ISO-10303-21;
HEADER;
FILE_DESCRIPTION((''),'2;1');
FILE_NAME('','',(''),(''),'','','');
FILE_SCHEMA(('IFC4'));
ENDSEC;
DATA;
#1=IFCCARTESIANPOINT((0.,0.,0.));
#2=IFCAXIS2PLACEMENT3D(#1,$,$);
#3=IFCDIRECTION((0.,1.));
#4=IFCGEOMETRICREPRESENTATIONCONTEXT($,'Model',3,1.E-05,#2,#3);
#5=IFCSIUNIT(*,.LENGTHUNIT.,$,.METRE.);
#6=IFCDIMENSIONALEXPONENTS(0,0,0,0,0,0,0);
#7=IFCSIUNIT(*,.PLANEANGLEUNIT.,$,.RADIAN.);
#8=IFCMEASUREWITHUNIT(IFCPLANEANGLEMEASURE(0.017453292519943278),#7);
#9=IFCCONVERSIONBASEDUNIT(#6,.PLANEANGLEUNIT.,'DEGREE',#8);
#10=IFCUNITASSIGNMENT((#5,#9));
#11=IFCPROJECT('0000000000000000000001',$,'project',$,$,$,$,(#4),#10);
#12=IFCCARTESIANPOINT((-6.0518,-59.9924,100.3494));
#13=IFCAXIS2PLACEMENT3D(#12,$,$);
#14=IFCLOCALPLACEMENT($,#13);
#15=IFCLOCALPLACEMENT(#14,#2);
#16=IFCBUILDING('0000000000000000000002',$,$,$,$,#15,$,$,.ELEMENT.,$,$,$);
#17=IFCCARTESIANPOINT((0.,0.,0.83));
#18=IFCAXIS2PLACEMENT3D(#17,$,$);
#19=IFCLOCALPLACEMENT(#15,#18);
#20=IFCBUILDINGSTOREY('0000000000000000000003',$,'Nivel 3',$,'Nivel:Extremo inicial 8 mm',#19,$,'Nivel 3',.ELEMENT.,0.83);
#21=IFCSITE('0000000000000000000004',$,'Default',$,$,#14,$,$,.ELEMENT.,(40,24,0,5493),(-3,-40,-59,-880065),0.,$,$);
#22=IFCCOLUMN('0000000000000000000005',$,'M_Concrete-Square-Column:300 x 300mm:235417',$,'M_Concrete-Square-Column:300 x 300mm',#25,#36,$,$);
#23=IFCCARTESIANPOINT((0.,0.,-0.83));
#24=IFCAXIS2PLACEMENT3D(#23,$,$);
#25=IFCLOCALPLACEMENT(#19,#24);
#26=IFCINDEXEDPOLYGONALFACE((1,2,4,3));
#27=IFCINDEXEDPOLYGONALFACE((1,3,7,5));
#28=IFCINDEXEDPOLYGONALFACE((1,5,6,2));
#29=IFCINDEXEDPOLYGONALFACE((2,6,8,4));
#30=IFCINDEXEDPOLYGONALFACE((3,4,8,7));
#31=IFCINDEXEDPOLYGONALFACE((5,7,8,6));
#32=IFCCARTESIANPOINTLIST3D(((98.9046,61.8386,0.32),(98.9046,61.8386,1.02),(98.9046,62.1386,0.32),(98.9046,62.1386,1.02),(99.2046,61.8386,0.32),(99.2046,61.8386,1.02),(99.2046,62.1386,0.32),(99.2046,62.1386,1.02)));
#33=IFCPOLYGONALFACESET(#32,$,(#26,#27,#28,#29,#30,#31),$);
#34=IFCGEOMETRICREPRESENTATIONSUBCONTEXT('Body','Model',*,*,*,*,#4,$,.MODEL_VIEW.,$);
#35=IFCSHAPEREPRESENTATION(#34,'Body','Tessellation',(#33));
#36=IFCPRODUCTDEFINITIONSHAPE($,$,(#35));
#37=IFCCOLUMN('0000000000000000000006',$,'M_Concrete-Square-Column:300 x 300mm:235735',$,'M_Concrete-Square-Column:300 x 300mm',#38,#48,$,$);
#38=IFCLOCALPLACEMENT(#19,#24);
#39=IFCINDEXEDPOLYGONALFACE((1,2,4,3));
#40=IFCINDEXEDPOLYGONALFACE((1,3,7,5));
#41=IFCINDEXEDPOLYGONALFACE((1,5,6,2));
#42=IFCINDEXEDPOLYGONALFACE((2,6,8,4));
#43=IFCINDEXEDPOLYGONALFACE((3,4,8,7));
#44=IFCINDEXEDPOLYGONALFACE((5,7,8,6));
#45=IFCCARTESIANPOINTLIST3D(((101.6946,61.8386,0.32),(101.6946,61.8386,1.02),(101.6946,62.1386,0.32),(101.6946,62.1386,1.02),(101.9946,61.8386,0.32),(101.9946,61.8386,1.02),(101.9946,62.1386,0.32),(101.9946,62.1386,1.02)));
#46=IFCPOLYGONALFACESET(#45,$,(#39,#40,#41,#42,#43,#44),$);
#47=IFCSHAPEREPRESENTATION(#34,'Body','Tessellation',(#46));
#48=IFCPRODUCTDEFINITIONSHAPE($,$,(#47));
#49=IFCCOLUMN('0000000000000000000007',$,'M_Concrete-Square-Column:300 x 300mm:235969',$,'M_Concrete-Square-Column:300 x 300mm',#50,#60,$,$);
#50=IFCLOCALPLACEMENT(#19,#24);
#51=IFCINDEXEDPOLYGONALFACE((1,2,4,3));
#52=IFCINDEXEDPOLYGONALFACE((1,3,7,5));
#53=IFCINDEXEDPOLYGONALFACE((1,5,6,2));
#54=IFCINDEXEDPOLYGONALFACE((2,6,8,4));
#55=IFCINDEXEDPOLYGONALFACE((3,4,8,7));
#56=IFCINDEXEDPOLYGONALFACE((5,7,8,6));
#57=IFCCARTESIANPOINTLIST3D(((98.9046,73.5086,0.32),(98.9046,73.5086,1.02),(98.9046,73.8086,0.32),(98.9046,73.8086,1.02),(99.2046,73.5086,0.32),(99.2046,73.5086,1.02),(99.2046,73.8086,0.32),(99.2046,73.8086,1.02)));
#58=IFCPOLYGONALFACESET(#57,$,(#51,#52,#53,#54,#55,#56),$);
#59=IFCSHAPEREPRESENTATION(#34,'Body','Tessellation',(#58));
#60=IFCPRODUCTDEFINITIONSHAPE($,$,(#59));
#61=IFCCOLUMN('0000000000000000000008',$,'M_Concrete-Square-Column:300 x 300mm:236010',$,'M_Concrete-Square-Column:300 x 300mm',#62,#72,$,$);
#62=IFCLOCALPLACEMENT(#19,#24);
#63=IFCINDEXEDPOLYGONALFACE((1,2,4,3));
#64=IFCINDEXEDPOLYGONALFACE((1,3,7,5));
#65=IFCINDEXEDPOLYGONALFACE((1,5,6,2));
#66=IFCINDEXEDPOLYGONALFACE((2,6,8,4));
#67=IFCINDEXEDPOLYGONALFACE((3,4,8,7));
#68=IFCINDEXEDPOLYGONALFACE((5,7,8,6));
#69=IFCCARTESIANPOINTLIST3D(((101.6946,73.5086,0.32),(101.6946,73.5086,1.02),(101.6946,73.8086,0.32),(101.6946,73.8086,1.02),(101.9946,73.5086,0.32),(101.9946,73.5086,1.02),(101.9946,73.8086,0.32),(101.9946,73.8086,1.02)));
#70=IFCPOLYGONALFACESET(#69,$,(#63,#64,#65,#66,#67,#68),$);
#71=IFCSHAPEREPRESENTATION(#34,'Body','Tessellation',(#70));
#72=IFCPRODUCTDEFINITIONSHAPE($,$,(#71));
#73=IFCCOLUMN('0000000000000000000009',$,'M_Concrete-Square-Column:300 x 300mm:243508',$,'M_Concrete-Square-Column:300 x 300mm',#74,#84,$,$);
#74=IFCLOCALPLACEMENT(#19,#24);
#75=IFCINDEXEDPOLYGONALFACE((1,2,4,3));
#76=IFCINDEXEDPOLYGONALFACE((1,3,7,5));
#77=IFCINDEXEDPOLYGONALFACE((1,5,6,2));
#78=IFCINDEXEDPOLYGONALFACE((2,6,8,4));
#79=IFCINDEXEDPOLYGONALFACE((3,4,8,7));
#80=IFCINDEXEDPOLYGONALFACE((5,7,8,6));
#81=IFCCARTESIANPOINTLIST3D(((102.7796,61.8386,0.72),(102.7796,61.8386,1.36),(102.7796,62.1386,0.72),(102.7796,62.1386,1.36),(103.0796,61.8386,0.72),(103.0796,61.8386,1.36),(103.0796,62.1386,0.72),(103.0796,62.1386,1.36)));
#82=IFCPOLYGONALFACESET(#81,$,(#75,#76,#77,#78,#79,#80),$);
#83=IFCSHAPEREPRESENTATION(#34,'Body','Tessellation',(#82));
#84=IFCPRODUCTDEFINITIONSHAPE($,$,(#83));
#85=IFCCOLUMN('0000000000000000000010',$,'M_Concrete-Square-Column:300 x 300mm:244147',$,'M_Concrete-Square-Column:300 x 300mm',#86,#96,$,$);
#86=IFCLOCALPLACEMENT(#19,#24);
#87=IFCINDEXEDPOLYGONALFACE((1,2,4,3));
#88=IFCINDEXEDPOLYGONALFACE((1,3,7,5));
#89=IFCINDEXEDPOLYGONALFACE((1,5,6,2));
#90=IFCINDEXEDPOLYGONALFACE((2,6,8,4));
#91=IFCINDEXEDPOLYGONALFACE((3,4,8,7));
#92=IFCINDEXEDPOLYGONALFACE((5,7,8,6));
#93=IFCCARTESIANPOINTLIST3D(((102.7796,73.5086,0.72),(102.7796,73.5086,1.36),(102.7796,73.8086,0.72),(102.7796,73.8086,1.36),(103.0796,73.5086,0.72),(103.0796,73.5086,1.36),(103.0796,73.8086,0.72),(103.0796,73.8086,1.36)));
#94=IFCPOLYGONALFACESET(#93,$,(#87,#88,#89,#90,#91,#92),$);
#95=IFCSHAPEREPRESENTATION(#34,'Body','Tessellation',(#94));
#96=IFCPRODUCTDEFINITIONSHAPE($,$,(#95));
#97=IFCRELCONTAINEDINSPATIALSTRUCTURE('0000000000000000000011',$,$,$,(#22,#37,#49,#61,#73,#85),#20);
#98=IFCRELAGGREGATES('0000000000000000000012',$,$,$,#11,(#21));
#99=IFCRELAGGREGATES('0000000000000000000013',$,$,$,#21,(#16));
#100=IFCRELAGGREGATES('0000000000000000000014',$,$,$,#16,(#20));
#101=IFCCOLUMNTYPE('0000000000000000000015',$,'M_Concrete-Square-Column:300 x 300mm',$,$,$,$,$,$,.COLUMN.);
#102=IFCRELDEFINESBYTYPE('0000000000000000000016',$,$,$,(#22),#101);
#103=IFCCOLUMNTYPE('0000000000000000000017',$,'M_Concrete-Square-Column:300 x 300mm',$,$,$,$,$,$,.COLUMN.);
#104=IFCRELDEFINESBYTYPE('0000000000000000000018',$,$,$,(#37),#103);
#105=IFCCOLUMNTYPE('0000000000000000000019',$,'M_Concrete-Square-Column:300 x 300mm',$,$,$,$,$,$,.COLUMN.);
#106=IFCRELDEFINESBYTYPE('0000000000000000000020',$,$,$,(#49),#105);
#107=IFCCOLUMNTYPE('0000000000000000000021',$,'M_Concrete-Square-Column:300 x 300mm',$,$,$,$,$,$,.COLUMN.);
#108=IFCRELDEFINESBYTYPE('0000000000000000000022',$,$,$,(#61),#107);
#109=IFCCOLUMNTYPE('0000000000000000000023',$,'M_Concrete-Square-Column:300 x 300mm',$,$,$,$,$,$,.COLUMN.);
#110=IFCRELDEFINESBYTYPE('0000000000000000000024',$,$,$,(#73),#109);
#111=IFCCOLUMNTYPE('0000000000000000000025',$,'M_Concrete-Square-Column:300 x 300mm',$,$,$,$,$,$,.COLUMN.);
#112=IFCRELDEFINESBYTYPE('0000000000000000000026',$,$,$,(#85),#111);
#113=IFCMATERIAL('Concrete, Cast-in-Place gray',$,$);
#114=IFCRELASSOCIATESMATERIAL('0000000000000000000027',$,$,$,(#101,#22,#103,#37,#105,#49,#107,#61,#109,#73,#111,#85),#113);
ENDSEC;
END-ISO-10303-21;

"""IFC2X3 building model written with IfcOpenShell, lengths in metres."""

from ifc_helpers import new_model, entity, si_unit, converted_unit, direction, frame, origin, origin_2d_with_axis, place, context, subcontext, project, spatial, rectangle, extrude, source, transform, mapped, material, type_object, type_shapes, element, save


model = new_model("IFC2X3")

# Units and contexts
model_context = context("Model", 3, precision=1e-05, world=origin(), true_north=direction((0.0, 1.0)))
body_context = subcontext(model_context, "Body", "Model", "MODEL_VIEW")
ifc_project = project(units=[si_unit("LENGTHUNIT", "METRE"), converted_unit("PLANEANGLEUNIT", "DEGREE", entity("IfcPlaneAngleMeasure", 0.017453292519943278), si_unit("PLANEANGLEUNIT", "RADIAN"), dimensions=[0, 0, 0, 0, 0, 0, 0])], contexts=[model_context])

# Site, building, storey
site_placement = place(None, frame((-6.0518, -59.9924, 100.3494)))
site = spatial("IfcSite", under=ifc_project, at=site_placement, Name="Default", CompositionType="ELEMENT", RefLatitude=(40, 24, 0, 5493), RefLongitude=(-3, -40, -59, -880065), RefElevation=0.0)
building_placement = place(site_placement, origin())
building = spatial("IfcBuilding", under=site, at=building_placement, CompositionType="ELEMENT")
storey_placement = place(building_placement, frame((0.0, 0.0, 0.83)))
storey = spatial("IfcBuildingStorey", under=building, at=storey_placement, Name="Nivel 3", ObjectType="Nivel:Extremo inicial 8 mm", LongName="Nivel 3", CompositionType="ELEMENT", Elevation=0.83)

# Columns
ifc_material_1 = material(Name="Concrete, Cast-in-Place gray")
column_type_1 = type_object("IfcColumnType", Name="M_Concrete-Square-Column:300 x 300mm", PredefinedType="COLUMN", material=ifc_material_1)
shared_shape_1 = source(origin(), body_context, "Body", "SweptSolid", [
    extrude(rectangle(XDim=0.3, YDim=0.3, at=origin_2d_with_axis()), frame((99.0546, 61.9886, 0.32), z_axis=(0.0, 0.0, 1.0), x_axis=(-1.0, 0.0, 0.0)), (0.0, 0.0, 1.0), 0.7),
])
type_shapes(column_type_1, [shared_shape_1])
column_1_placement = place(storey_placement, frame((0.0, 0.0, -0.83)))
element("IfcColumn", 1, at=column_1_placement, inside=storey, type_object=column_type_1, material=ifc_material_1, Name="M_Concrete-Square-Column:300 x 300mm:235417", ObjectType="M_Concrete-Square-Column:300 x 300mm", context=body_context, shape_type="MappedRepresentation", body=[
    mapped(shared_shape_1, transform((0.0, 0.0, 0.0), scale=1.0)),
])
column_type_2 = type_object("IfcColumnType", Name="M_Concrete-Square-Column:300 x 300mm", PredefinedType="COLUMN", material=ifc_material_1)
shared_shape_2 = source(origin(), body_context, "Body", "SweptSolid", [
    extrude(rectangle(XDim=0.3, YDim=0.3, at=origin_2d_with_axis()), frame((101.8446, 61.9886, 0.32), z_axis=(0.0, 0.0, 1.0), x_axis=(-1.0, 0.0, 0.0)), (0.0, 0.0, 1.0), 0.7),
])
type_shapes(column_type_2, [shared_shape_2])
column_2_placement = place(storey_placement, frame((0.0, 0.0, -0.83)))
element("IfcColumn", 2, at=column_2_placement, inside=storey, type_object=column_type_2, material=ifc_material_1, Name="M_Concrete-Square-Column:300 x 300mm:235735", ObjectType="M_Concrete-Square-Column:300 x 300mm", context=body_context, shape_type="MappedRepresentation", body=[
    mapped(shared_shape_2, transform((0.0, 0.0, 0.0), scale=1.0)),
])
column_type_3 = type_object("IfcColumnType", Name="M_Concrete-Square-Column:300 x 300mm", PredefinedType="COLUMN", material=ifc_material_1)
shared_shape_3 = source(origin(), body_context, "Body", "SweptSolid", [
    extrude(rectangle(XDim=0.3, YDim=0.3, at=origin_2d_with_axis()), frame((99.0546, 73.6586, 0.32), z_axis=(0.0, 0.0, 1.0), x_axis=(-1.0, 0.0, 0.0)), (0.0, 0.0, 1.0), 0.7),
])
type_shapes(column_type_3, [shared_shape_3])
column_3_placement = place(storey_placement, frame((0.0, 0.0, -0.83)))
element("IfcColumn", 3, at=column_3_placement, inside=storey, type_object=column_type_3, material=ifc_material_1, Name="M_Concrete-Square-Column:300 x 300mm:235969", ObjectType="M_Concrete-Square-Column:300 x 300mm", context=body_context, shape_type="MappedRepresentation", body=[
    mapped(shared_shape_3, transform((0.0, 0.0, 0.0), scale=1.0)),
])
column_type_4 = type_object("IfcColumnType", Name="M_Concrete-Square-Column:300 x 300mm", PredefinedType="COLUMN", material=ifc_material_1)
shared_shape_4 = source(origin(), body_context, "Body", "SweptSolid", [
    extrude(rectangle(XDim=0.3, YDim=0.3, at=origin_2d_with_axis()), frame((101.8446, 73.6586, 0.32), z_axis=(0.0, 0.0, 1.0), x_axis=(-1.0, 0.0, 0.0)), (0.0, 0.0, 1.0), 0.7),
])
type_shapes(column_type_4, [shared_shape_4])
column_4_placement = place(storey_placement, frame((0.0, 0.0, -0.83)))
element("IfcColumn", 4, at=column_4_placement, inside=storey, type_object=column_type_4, material=ifc_material_1, Name="M_Concrete-Square-Column:300 x 300mm:236010", ObjectType="M_Concrete-Square-Column:300 x 300mm", context=body_context, shape_type="MappedRepresentation", body=[
    mapped(shared_shape_4, transform((0.0, 0.0, 0.0), scale=1.0)),
])
column_type_5 = type_object("IfcColumnType", Name="M_Concrete-Square-Column:300 x 300mm", PredefinedType="COLUMN", material=ifc_material_1)
shared_shape_5 = source(origin(), body_context, "Body", "SweptSolid", [
    extrude(rectangle(XDim=0.3, YDim=0.3, at=origin_2d_with_axis()), frame((102.9296, 61.9886, 0.72), z_axis=(0.0, 0.0, 1.0), x_axis=(-1.0, 0.0, 0.0)), (0.0, 0.0, 1.0), 0.64),
])
type_shapes(column_type_5, [shared_shape_5])
column_5_placement = place(storey_placement, frame((0.0, 0.0, -0.83)))
element("IfcColumn", 5, at=column_5_placement, inside=storey, type_object=column_type_5, material=ifc_material_1, Name="M_Concrete-Square-Column:300 x 300mm:243508", ObjectType="M_Concrete-Square-Column:300 x 300mm", context=body_context, shape_type="MappedRepresentation", body=[
    mapped(shared_shape_5, transform((0.0, 0.0, 0.0), scale=1.0)),
])
column_type_6 = type_object("IfcColumnType", Name="M_Concrete-Square-Column:300 x 300mm", PredefinedType="COLUMN", material=ifc_material_1)
shared_shape_6 = source(origin(), body_context, "Body", "SweptSolid", [
    extrude(rectangle(XDim=0.3, YDim=0.3, at=origin_2d_with_axis()), frame((102.9296, 73.6586, 0.72), z_axis=(0.0, 0.0, 1.0), x_axis=(-1.0, 0.0, 0.0)), (0.0, 0.0, 1.0), 0.64),
])
type_shapes(column_type_6, [shared_shape_6])
column_6_placement = place(storey_placement, frame((0.0, 0.0, -0.83)))
element("IfcColumn", 6, at=column_6_placement, inside=storey, type_object=column_type_6, material=ifc_material_1, Name="M_Concrete-Square-Column:300 x 300mm:244147", ObjectType="M_Concrete-Square-Column:300 x 300mm", context=body_context, shape_type="MappedRepresentation", body=[
    mapped(shared_shape_6, transform((0.0, 0.0, 0.0), scale=1.0)),
])

save(model, "model.ifc")
